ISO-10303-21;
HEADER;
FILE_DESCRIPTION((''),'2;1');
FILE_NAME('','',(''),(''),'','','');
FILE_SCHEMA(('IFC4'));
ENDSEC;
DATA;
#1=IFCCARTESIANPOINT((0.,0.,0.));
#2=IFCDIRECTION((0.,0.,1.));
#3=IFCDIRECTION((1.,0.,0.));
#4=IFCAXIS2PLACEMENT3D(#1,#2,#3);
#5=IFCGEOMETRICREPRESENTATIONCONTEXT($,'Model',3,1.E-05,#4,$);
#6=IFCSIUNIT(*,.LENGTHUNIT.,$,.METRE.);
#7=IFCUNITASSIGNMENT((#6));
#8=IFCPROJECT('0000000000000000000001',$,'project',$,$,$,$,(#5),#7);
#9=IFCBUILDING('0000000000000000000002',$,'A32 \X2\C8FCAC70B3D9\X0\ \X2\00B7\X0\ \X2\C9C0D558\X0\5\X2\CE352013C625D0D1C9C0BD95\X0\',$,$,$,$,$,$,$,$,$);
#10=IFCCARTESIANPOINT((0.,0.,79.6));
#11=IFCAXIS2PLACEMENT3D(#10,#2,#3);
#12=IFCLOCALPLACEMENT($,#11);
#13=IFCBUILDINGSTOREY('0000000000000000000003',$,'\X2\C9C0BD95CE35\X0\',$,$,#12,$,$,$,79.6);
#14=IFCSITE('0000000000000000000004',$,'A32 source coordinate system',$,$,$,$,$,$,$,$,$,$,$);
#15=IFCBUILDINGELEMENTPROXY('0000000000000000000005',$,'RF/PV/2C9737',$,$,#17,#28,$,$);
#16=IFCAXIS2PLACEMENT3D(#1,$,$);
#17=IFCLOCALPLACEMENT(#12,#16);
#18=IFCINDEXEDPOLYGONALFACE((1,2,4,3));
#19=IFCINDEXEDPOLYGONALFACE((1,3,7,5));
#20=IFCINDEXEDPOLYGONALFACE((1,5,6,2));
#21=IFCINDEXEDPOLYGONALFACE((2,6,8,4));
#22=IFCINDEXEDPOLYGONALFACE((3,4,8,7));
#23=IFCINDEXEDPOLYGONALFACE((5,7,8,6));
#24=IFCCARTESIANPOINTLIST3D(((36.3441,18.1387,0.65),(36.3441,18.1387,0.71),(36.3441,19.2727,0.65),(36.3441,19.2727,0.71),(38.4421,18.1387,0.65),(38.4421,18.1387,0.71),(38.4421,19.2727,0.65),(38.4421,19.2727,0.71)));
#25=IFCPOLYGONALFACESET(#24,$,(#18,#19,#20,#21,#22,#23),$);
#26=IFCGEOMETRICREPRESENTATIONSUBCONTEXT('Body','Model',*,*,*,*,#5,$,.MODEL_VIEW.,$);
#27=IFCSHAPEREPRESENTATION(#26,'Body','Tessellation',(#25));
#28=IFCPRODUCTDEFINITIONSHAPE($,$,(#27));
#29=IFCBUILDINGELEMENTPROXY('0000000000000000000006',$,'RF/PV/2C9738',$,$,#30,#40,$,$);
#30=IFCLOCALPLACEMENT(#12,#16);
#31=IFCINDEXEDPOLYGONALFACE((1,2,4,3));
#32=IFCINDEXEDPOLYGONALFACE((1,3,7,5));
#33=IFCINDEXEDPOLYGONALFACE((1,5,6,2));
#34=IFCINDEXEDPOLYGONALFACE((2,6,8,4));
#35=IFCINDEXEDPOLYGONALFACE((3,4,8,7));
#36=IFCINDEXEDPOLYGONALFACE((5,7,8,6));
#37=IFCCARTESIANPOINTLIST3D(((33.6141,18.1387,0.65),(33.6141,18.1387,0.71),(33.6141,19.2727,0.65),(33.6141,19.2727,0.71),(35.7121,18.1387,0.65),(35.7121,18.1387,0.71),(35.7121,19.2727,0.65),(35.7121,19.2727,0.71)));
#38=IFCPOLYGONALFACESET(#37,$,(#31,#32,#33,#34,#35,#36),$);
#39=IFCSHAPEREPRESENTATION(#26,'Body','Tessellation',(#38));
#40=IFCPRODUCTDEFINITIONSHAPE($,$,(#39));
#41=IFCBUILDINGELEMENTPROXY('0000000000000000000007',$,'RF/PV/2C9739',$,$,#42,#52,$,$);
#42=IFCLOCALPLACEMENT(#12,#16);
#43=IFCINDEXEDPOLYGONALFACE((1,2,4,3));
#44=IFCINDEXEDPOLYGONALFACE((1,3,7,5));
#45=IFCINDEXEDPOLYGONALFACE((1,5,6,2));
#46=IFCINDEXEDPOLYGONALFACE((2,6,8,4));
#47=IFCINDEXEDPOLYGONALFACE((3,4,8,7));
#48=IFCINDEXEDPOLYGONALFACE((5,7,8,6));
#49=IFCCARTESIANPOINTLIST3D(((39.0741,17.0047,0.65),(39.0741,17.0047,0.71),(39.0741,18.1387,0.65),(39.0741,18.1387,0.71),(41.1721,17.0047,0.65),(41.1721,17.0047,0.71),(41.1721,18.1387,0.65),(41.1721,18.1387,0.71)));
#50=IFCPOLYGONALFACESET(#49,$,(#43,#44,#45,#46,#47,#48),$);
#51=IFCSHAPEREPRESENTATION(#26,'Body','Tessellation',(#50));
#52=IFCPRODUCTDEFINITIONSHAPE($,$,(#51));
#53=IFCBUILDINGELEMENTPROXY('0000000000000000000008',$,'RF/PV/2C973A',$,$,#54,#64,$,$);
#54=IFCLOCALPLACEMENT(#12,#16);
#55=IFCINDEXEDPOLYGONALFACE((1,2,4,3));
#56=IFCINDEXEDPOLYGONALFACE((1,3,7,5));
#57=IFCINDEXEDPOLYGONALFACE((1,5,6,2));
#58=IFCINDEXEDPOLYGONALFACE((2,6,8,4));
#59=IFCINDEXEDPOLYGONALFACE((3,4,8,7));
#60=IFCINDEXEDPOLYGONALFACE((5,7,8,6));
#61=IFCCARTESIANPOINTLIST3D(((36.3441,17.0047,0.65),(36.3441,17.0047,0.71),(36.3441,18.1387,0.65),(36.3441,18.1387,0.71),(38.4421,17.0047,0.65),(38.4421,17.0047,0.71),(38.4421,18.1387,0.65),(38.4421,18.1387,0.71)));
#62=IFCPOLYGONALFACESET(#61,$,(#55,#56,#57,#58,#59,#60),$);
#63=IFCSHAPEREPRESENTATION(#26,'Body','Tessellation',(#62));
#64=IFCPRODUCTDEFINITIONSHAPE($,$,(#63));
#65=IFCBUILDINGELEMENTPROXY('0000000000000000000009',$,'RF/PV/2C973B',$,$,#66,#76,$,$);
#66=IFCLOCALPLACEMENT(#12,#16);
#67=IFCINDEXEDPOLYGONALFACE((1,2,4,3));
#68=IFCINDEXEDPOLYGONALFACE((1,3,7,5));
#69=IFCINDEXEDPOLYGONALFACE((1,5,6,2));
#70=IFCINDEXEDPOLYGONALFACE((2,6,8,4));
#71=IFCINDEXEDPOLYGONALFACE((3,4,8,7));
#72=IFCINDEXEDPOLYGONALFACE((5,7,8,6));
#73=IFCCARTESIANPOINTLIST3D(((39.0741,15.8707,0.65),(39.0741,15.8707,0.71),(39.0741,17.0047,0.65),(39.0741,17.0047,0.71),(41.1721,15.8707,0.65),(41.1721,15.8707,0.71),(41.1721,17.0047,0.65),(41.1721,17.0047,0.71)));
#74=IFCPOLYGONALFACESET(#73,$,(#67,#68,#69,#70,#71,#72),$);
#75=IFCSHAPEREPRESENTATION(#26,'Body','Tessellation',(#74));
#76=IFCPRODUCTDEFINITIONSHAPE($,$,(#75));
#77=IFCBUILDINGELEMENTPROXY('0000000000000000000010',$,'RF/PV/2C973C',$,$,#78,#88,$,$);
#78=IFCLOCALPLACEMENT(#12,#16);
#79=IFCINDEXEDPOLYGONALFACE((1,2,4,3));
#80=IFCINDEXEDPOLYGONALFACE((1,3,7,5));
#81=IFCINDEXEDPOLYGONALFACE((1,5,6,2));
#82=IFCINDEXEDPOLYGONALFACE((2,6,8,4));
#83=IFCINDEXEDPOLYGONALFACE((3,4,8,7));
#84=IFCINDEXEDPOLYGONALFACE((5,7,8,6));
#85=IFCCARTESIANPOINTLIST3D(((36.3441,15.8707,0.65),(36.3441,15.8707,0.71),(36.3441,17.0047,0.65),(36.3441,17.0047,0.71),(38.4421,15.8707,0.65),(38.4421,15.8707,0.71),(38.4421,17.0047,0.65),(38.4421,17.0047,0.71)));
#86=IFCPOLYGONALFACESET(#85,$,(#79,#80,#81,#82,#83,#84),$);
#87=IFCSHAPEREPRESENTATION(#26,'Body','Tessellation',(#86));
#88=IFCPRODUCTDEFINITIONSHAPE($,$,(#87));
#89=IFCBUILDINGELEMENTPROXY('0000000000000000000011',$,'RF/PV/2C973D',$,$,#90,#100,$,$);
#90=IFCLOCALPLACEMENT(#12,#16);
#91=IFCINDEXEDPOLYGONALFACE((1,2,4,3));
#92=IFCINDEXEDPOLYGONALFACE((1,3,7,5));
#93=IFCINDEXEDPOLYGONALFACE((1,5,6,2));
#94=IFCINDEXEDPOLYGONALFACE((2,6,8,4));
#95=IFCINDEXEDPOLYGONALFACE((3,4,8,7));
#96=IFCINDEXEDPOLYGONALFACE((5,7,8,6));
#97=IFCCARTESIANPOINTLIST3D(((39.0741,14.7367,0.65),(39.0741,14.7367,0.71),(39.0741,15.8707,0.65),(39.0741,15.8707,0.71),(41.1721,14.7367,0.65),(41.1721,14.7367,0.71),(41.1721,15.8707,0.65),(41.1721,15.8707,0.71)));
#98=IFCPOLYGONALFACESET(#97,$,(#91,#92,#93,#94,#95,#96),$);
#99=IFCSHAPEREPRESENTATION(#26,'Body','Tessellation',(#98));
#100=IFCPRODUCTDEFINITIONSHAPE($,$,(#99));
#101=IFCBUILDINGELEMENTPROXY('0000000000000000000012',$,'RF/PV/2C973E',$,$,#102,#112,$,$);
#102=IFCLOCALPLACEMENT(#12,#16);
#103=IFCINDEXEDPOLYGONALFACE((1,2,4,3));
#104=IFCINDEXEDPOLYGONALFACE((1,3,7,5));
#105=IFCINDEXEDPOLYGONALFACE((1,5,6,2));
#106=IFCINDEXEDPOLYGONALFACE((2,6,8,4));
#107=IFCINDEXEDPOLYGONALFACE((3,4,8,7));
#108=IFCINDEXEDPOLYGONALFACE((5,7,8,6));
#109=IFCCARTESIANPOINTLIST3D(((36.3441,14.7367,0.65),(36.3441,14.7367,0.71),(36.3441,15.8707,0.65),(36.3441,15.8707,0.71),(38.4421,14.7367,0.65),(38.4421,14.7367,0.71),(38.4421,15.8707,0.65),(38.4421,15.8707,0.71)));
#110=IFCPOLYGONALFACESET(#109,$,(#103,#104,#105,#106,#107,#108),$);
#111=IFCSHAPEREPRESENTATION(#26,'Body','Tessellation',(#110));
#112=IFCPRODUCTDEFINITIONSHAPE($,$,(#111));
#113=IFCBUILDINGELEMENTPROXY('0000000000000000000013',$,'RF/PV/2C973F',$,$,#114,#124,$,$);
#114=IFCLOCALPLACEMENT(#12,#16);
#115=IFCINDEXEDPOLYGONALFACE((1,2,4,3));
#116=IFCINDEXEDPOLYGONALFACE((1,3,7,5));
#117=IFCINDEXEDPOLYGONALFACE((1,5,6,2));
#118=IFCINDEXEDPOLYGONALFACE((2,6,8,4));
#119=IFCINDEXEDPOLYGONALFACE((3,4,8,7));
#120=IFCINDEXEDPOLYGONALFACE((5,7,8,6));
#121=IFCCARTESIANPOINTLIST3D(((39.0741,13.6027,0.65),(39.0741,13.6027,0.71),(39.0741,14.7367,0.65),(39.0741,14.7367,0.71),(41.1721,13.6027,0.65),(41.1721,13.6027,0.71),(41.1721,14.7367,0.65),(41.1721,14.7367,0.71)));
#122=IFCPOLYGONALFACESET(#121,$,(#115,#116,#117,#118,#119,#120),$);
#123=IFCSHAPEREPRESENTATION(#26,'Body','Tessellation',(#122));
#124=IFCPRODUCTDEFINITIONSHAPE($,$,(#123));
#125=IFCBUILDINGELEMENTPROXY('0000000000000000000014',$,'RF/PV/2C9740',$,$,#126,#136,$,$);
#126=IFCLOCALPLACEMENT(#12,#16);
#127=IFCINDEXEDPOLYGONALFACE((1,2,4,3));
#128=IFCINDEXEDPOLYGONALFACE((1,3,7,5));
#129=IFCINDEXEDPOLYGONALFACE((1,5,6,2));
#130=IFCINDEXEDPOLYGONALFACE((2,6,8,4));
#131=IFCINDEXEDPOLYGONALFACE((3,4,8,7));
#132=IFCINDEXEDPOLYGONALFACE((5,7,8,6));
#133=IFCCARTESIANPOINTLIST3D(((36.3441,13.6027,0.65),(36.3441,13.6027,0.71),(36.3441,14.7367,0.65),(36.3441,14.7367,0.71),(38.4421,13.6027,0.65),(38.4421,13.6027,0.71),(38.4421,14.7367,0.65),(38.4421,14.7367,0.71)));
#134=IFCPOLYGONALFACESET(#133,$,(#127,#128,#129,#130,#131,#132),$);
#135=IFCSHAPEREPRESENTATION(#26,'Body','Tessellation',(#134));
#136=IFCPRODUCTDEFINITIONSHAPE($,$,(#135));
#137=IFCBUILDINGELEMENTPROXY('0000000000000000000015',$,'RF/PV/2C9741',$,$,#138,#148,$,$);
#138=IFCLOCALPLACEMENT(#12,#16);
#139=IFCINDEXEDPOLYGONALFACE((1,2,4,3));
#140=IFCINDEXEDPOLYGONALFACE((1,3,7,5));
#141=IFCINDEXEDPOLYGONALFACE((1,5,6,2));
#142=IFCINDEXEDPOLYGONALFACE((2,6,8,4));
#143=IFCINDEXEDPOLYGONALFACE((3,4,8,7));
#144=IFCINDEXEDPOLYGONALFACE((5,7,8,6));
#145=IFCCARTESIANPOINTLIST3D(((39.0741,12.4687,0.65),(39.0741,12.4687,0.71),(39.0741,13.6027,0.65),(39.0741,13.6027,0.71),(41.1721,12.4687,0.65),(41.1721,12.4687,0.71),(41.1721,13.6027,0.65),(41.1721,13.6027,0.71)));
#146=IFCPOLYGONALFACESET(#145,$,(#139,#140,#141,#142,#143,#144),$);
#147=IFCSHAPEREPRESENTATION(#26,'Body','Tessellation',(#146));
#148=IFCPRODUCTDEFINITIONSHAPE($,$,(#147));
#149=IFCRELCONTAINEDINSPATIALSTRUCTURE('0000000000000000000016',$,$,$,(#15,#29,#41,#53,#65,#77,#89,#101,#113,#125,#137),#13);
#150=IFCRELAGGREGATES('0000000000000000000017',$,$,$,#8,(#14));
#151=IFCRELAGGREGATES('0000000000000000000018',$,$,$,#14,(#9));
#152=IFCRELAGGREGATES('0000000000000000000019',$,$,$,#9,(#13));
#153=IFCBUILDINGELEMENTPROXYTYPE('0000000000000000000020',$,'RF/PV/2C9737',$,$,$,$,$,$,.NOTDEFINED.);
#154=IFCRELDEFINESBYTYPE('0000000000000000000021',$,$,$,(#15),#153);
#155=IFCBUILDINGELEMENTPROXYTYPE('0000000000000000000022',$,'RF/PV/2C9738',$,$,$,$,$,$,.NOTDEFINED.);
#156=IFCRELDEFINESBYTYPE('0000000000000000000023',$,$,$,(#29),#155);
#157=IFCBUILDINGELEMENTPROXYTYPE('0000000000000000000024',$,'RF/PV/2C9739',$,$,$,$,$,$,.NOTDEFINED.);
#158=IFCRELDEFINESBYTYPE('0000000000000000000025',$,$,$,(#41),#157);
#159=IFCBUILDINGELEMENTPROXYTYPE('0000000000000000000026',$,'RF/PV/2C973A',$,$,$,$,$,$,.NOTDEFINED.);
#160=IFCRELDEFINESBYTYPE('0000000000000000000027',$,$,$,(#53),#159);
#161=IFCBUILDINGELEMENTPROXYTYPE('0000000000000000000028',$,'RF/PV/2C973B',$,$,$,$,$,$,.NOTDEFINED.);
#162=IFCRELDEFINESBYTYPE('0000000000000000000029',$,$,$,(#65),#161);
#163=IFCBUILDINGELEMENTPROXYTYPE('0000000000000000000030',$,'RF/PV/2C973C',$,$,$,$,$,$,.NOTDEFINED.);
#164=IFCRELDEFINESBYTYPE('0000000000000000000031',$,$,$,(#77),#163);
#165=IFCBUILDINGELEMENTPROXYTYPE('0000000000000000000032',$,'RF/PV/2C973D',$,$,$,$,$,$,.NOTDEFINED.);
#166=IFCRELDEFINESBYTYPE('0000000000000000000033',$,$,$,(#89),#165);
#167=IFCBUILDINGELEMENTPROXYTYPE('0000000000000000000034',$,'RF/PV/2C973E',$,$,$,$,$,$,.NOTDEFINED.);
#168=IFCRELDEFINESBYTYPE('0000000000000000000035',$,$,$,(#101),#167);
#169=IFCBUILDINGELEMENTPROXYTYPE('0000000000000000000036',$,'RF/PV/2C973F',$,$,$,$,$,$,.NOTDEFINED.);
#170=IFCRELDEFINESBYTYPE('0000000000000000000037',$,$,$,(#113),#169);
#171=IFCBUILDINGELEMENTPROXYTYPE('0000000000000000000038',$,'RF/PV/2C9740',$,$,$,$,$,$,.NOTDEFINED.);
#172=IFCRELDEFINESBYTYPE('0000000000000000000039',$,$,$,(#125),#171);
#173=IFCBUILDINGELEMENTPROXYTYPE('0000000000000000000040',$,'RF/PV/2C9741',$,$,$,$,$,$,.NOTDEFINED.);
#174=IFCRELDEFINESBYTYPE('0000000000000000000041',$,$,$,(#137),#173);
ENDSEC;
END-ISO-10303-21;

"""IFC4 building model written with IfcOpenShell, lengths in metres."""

from ifc_helpers import new_model, si_unit, frame, origin, origin_with_axes, place, context, subcontext, project, spatial, polyline, outline, extrude, source, transform, mapped, type_object, type_shapes, element, save


model = new_model("IFC4")

# Units and contexts
model_context = context("Model", 3, precision=1e-05, world=origin_with_axes())
body_context = subcontext(model_context, "Body", "Model", "MODEL_VIEW")
ifc_project = project(units=[si_unit("LENGTHUNIT", "METRE")], contexts=[model_context])

# Site, building, storey
site = spatial("IfcSite", under=ifc_project, Name="A32 source coordinate system")
building = spatial("IfcBuilding", under=site, Name="A32 주거동 · 지하5층–옥탑지붕")
storey_placement = place(None, frame((0.0, 0.0, 79.6), z_axis=(0.0, 0.0, 1.0), x_axis=(1.0, 0.0, 0.0)))
storey = spatial("IfcBuildingStorey", under=building, at=storey_placement, Name="지붕층", Elevation=79.6)

# Building element proxies
building_element_proxy_type_1 = type_object("IfcBuildingElementProxyType", Name="RF/PV/2C9737", PredefinedType="NOTDEFINED")
shared_shape_1 = source(origin(), body_context, "Body", "SweptSolid", [
    extrude(outline(polyline([(38.4421, 19.2727), (38.4421, 18.1387), (36.3441, 18.1387), (36.3441, 19.2727), (38.4421, 19.2727)])), frame((0.0, 0.0, 0.65)), (0.0, 0.0, 1.0), 0.06),
])
type_shapes(building_element_proxy_type_1, [shared_shape_1])
proxy_1_placement = place(storey_placement, origin_with_axes())
element("IfcBuildingElementProxy", 1, at=proxy_1_placement, inside=storey, type_object=building_element_proxy_type_1, Name="RF/PV/2C9737", context=body_context, shape_type="MappedRepresentation", body=[
    mapped(shared_shape_1, transform((0.0, 0.0, 0.0), scale=1.0)),
])
building_element_proxy_type_2 = type_object("IfcBuildingElementProxyType", Name="RF/PV/2C9738", PredefinedType="NOTDEFINED")
shared_shape_2 = source(origin(), body_context, "Body", "SweptSolid", [
    extrude(outline(polyline([(35.7121, 19.2727), (35.7121, 18.1387), (33.6141, 18.1387), (33.6141, 19.2727), (35.7121, 19.2727)])), frame((0.0, 0.0, 0.65)), (0.0, 0.0, 1.0), 0.06),
])
type_shapes(building_element_proxy_type_2, [shared_shape_2])
proxy_2_placement = place(storey_placement, origin_with_axes())
element("IfcBuildingElementProxy", 2, at=proxy_2_placement, inside=storey, type_object=building_element_proxy_type_2, Name="RF/PV/2C9738", context=body_context, shape_type="MappedRepresentation", body=[
    mapped(shared_shape_2, transform((0.0, 0.0, 0.0), scale=1.0)),
])
building_element_proxy_type_3 = type_object("IfcBuildingElementProxyType", Name="RF/PV/2C9739", PredefinedType="NOTDEFINED")
shared_shape_3 = source(origin(), body_context, "Body", "SweptSolid", [
    extrude(outline(polyline([(41.1721, 18.1387), (41.1721, 17.0047), (39.0741, 17.0047), (39.0741, 18.1387), (41.1721, 18.1387)])), frame((0.0, 0.0, 0.65)), (0.0, 0.0, 1.0), 0.06),
])
type_shapes(building_element_proxy_type_3, [shared_shape_3])
proxy_3_placement = place(storey_placement, origin_with_axes())
element("IfcBuildingElementProxy", 3, at=proxy_3_placement, inside=storey, type_object=building_element_proxy_type_3, Name="RF/PV/2C9739", context=body_context, shape_type="MappedRepresentation", body=[
    mapped(shared_shape_3, transform((0.0, 0.0, 0.0), scale=1.0)),
])
building_element_proxy_type_4 = type_object("IfcBuildingElementProxyType", Name="RF/PV/2C973A", PredefinedType="NOTDEFINED")
shared_shape_4 = source(origin(), body_context, "Body", "SweptSolid", [
    extrude(outline(polyline([(38.4421, 18.1387), (38.4421, 17.0047), (36.3441, 17.0047), (36.3441, 18.1387), (38.4421, 18.1387)])), frame((0.0, 0.0, 0.65)), (0.0, 0.0, 1.0), 0.06),
])
type_shapes(building_element_proxy_type_4, [shared_shape_4])
proxy_4_placement = place(storey_placement, origin_with_axes())
element("IfcBuildingElementProxy", 4, at=proxy_4_placement, inside=storey, type_object=building_element_proxy_type_4, Name="RF/PV/2C973A", context=body_context, shape_type="MappedRepresentation", body=[
    mapped(shared_shape_4, transform((0.0, 0.0, 0.0), scale=1.0)),
])
building_element_proxy_type_5 = type_object("IfcBuildingElementProxyType", Name="RF/PV/2C973B", PredefinedType="NOTDEFINED")
shared_shape_5 = source(origin(), body_context, "Body", "SweptSolid", [
    extrude(outline(polyline([(41.1721, 17.0047), (41.1721, 15.8707), (39.0741, 15.8707), (39.0741, 17.0047), (41.1721, 17.0047)])), frame((0.0, 0.0, 0.65)), (0.0, 0.0, 1.0), 0.06),
])
type_shapes(building_element_proxy_type_5, [shared_shape_5])
proxy_5_placement = place(storey_placement, origin_with_axes())
element("IfcBuildingElementProxy", 5, at=proxy_5_placement, inside=storey, type_object=building_element_proxy_type_5, Name="RF/PV/2C973B", context=body_context, shape_type="MappedRepresentation", body=[
    mapped(shared_shape_5, transform((0.0, 0.0, 0.0), scale=1.0)),
])
building_element_proxy_type_6 = type_object("IfcBuildingElementProxyType", Name="RF/PV/2C973C", PredefinedType="NOTDEFINED")
shared_shape_6 = source(origin(), body_context, "Body", "SweptSolid", [
    extrude(outline(polyline([(38.4421, 17.0047), (38.4421, 15.8707), (36.3441, 15.8707), (36.3441, 17.0047), (38.4421, 17.0047)])), frame((0.0, 0.0, 0.65)), (0.0, 0.0, 1.0), 0.06),
])
type_shapes(building_element_proxy_type_6, [shared_shape_6])
proxy_6_placement = place(storey_placement, origin_with_axes())
element("IfcBuildingElementProxy", 6, at=proxy_6_placement, inside=storey, type_object=building_element_proxy_type_6, Name="RF/PV/2C973C", context=body_context, shape_type="MappedRepresentation", body=[
    mapped(shared_shape_6, transform((0.0, 0.0, 0.0), scale=1.0)),
])
building_element_proxy_type_7 = type_object("IfcBuildingElementProxyType", Name="RF/PV/2C973D", PredefinedType="NOTDEFINED")
shared_shape_7 = source(origin(), body_context, "Body", "SweptSolid", [
    extrude(outline(polyline([(41.1721, 15.8707), (41.1721, 14.7367), (39.0741, 14.7367), (39.0741, 15.8707), (41.1721, 15.8707)])), frame((0.0, 0.0, 0.65)), (0.0, 0.0, 1.0), 0.06),
])
type_shapes(building_element_proxy_type_7, [shared_shape_7])
proxy_7_placement = place(storey_placement, origin_with_axes())
element("IfcBuildingElementProxy", 7, at=proxy_7_placement, inside=storey, type_object=building_element_proxy_type_7, Name="RF/PV/2C973D", context=body_context, shape_type="MappedRepresentation", body=[
    mapped(shared_shape_7, transform((0.0, 0.0, 0.0), scale=1.0)),
])
building_element_proxy_type_8 = type_object("IfcBuildingElementProxyType", Name="RF/PV/2C973E", PredefinedType="NOTDEFINED")
shared_shape_8 = source(origin(), body_context, "Body", "SweptSolid", [
    extrude(outline(polyline([(38.4421, 15.8707), (38.4421, 14.7367), (36.3441, 14.7367), (36.3441, 15.8707), (38.4421, 15.8707)])), frame((0.0, 0.0, 0.65)), (0.0, 0.0, 1.0), 0.06),
])
type_shapes(building_element_proxy_type_8, [shared_shape_8])
proxy_8_placement = place(storey_placement, origin_with_axes())
element("IfcBuildingElementProxy", 8, at=proxy_8_placement, inside=storey, type_object=building_element_proxy_type_8, Name="RF/PV/2C973E", context=body_context, shape_type="MappedRepresentation", body=[
    mapped(shared_shape_8, transform((0.0, 0.0, 0.0), scale=1.0)),
])
building_element_proxy_type_9 = type_object("IfcBuildingElementProxyType", Name="RF/PV/2C973F", PredefinedType="NOTDEFINED")
shared_shape_9 = source(origin(), body_context, "Body", "SweptSolid", [
    extrude(outline(polyline([(41.1721, 14.7367), (41.1721, 13.6027), (39.0741, 13.6027), (39.0741, 14.7367), (41.1721, 14.7367)])), frame((0.0, 0.0, 0.65)), (0.0, 0.0, 1.0), 0.06),
])
type_shapes(building_element_proxy_type_9, [shared_shape_9])
proxy_9_placement = place(storey_placement, origin_with_axes())
element("IfcBuildingElementProxy", 9, at=proxy_9_placement, inside=storey, type_object=building_element_proxy_type_9, Name="RF/PV/2C973F", context=body_context, shape_type="MappedRepresentation", body=[
    mapped(shared_shape_9, transform((0.0, 0.0, 0.0), scale=1.0)),
])
building_element_proxy_type_10 = type_object("IfcBuildingElementProxyType", Name="RF/PV/2C9740", PredefinedType="NOTDEFINED")
shared_shape_10 = source(origin(), body_context, "Body", "SweptSolid", [
    extrude(outline(polyline([(38.4421, 14.7367), (38.4421, 13.6027), (36.3441, 13.6027), (36.3441, 14.7367), (38.4421, 14.7367)])), frame((0.0, 0.0, 0.65)), (0.0, 0.0, 1.0), 0.06),
])
type_shapes(building_element_proxy_type_10, [shared_shape_10])
proxy_10_placement = place(storey_placement, origin_with_axes())
element("IfcBuildingElementProxy", 10, at=proxy_10_placement, inside=storey, type_object=building_element_proxy_type_10, Name="RF/PV/2C9740", context=body_context, shape_type="MappedRepresentation", body=[
    mapped(shared_shape_10, transform((0.0, 0.0, 0.0), scale=1.0)),
])
building_element_proxy_type_11 = type_object("IfcBuildingElementProxyType", Name="RF/PV/2C9741", PredefinedType="NOTDEFINED")
shared_shape_11 = source(origin(), body_context, "Body", "SweptSolid", [
    extrude(outline(polyline([(41.1721, 13.6027), (41.1721, 12.4687), (39.0741, 12.4687), (39.0741, 13.6027), (41.1721, 13.6027)])), frame((0.0, 0.0, 0.65)), (0.0, 0.0, 1.0), 0.06),
])
type_shapes(building_element_proxy_type_11, [shared_shape_11])
proxy_11_placement = place(storey_placement, origin_with_axes())
element("IfcBuildingElementProxy", 11, at=proxy_11_placement, inside=storey, type_object=building_element_proxy_type_11, Name="RF/PV/2C9741", context=body_context, shape_type="MappedRepresentation", body=[
    mapped(shared_shape_11, transform((0.0, 0.0, 0.0), scale=1.0)),
])

save(model, "model.ifc")
